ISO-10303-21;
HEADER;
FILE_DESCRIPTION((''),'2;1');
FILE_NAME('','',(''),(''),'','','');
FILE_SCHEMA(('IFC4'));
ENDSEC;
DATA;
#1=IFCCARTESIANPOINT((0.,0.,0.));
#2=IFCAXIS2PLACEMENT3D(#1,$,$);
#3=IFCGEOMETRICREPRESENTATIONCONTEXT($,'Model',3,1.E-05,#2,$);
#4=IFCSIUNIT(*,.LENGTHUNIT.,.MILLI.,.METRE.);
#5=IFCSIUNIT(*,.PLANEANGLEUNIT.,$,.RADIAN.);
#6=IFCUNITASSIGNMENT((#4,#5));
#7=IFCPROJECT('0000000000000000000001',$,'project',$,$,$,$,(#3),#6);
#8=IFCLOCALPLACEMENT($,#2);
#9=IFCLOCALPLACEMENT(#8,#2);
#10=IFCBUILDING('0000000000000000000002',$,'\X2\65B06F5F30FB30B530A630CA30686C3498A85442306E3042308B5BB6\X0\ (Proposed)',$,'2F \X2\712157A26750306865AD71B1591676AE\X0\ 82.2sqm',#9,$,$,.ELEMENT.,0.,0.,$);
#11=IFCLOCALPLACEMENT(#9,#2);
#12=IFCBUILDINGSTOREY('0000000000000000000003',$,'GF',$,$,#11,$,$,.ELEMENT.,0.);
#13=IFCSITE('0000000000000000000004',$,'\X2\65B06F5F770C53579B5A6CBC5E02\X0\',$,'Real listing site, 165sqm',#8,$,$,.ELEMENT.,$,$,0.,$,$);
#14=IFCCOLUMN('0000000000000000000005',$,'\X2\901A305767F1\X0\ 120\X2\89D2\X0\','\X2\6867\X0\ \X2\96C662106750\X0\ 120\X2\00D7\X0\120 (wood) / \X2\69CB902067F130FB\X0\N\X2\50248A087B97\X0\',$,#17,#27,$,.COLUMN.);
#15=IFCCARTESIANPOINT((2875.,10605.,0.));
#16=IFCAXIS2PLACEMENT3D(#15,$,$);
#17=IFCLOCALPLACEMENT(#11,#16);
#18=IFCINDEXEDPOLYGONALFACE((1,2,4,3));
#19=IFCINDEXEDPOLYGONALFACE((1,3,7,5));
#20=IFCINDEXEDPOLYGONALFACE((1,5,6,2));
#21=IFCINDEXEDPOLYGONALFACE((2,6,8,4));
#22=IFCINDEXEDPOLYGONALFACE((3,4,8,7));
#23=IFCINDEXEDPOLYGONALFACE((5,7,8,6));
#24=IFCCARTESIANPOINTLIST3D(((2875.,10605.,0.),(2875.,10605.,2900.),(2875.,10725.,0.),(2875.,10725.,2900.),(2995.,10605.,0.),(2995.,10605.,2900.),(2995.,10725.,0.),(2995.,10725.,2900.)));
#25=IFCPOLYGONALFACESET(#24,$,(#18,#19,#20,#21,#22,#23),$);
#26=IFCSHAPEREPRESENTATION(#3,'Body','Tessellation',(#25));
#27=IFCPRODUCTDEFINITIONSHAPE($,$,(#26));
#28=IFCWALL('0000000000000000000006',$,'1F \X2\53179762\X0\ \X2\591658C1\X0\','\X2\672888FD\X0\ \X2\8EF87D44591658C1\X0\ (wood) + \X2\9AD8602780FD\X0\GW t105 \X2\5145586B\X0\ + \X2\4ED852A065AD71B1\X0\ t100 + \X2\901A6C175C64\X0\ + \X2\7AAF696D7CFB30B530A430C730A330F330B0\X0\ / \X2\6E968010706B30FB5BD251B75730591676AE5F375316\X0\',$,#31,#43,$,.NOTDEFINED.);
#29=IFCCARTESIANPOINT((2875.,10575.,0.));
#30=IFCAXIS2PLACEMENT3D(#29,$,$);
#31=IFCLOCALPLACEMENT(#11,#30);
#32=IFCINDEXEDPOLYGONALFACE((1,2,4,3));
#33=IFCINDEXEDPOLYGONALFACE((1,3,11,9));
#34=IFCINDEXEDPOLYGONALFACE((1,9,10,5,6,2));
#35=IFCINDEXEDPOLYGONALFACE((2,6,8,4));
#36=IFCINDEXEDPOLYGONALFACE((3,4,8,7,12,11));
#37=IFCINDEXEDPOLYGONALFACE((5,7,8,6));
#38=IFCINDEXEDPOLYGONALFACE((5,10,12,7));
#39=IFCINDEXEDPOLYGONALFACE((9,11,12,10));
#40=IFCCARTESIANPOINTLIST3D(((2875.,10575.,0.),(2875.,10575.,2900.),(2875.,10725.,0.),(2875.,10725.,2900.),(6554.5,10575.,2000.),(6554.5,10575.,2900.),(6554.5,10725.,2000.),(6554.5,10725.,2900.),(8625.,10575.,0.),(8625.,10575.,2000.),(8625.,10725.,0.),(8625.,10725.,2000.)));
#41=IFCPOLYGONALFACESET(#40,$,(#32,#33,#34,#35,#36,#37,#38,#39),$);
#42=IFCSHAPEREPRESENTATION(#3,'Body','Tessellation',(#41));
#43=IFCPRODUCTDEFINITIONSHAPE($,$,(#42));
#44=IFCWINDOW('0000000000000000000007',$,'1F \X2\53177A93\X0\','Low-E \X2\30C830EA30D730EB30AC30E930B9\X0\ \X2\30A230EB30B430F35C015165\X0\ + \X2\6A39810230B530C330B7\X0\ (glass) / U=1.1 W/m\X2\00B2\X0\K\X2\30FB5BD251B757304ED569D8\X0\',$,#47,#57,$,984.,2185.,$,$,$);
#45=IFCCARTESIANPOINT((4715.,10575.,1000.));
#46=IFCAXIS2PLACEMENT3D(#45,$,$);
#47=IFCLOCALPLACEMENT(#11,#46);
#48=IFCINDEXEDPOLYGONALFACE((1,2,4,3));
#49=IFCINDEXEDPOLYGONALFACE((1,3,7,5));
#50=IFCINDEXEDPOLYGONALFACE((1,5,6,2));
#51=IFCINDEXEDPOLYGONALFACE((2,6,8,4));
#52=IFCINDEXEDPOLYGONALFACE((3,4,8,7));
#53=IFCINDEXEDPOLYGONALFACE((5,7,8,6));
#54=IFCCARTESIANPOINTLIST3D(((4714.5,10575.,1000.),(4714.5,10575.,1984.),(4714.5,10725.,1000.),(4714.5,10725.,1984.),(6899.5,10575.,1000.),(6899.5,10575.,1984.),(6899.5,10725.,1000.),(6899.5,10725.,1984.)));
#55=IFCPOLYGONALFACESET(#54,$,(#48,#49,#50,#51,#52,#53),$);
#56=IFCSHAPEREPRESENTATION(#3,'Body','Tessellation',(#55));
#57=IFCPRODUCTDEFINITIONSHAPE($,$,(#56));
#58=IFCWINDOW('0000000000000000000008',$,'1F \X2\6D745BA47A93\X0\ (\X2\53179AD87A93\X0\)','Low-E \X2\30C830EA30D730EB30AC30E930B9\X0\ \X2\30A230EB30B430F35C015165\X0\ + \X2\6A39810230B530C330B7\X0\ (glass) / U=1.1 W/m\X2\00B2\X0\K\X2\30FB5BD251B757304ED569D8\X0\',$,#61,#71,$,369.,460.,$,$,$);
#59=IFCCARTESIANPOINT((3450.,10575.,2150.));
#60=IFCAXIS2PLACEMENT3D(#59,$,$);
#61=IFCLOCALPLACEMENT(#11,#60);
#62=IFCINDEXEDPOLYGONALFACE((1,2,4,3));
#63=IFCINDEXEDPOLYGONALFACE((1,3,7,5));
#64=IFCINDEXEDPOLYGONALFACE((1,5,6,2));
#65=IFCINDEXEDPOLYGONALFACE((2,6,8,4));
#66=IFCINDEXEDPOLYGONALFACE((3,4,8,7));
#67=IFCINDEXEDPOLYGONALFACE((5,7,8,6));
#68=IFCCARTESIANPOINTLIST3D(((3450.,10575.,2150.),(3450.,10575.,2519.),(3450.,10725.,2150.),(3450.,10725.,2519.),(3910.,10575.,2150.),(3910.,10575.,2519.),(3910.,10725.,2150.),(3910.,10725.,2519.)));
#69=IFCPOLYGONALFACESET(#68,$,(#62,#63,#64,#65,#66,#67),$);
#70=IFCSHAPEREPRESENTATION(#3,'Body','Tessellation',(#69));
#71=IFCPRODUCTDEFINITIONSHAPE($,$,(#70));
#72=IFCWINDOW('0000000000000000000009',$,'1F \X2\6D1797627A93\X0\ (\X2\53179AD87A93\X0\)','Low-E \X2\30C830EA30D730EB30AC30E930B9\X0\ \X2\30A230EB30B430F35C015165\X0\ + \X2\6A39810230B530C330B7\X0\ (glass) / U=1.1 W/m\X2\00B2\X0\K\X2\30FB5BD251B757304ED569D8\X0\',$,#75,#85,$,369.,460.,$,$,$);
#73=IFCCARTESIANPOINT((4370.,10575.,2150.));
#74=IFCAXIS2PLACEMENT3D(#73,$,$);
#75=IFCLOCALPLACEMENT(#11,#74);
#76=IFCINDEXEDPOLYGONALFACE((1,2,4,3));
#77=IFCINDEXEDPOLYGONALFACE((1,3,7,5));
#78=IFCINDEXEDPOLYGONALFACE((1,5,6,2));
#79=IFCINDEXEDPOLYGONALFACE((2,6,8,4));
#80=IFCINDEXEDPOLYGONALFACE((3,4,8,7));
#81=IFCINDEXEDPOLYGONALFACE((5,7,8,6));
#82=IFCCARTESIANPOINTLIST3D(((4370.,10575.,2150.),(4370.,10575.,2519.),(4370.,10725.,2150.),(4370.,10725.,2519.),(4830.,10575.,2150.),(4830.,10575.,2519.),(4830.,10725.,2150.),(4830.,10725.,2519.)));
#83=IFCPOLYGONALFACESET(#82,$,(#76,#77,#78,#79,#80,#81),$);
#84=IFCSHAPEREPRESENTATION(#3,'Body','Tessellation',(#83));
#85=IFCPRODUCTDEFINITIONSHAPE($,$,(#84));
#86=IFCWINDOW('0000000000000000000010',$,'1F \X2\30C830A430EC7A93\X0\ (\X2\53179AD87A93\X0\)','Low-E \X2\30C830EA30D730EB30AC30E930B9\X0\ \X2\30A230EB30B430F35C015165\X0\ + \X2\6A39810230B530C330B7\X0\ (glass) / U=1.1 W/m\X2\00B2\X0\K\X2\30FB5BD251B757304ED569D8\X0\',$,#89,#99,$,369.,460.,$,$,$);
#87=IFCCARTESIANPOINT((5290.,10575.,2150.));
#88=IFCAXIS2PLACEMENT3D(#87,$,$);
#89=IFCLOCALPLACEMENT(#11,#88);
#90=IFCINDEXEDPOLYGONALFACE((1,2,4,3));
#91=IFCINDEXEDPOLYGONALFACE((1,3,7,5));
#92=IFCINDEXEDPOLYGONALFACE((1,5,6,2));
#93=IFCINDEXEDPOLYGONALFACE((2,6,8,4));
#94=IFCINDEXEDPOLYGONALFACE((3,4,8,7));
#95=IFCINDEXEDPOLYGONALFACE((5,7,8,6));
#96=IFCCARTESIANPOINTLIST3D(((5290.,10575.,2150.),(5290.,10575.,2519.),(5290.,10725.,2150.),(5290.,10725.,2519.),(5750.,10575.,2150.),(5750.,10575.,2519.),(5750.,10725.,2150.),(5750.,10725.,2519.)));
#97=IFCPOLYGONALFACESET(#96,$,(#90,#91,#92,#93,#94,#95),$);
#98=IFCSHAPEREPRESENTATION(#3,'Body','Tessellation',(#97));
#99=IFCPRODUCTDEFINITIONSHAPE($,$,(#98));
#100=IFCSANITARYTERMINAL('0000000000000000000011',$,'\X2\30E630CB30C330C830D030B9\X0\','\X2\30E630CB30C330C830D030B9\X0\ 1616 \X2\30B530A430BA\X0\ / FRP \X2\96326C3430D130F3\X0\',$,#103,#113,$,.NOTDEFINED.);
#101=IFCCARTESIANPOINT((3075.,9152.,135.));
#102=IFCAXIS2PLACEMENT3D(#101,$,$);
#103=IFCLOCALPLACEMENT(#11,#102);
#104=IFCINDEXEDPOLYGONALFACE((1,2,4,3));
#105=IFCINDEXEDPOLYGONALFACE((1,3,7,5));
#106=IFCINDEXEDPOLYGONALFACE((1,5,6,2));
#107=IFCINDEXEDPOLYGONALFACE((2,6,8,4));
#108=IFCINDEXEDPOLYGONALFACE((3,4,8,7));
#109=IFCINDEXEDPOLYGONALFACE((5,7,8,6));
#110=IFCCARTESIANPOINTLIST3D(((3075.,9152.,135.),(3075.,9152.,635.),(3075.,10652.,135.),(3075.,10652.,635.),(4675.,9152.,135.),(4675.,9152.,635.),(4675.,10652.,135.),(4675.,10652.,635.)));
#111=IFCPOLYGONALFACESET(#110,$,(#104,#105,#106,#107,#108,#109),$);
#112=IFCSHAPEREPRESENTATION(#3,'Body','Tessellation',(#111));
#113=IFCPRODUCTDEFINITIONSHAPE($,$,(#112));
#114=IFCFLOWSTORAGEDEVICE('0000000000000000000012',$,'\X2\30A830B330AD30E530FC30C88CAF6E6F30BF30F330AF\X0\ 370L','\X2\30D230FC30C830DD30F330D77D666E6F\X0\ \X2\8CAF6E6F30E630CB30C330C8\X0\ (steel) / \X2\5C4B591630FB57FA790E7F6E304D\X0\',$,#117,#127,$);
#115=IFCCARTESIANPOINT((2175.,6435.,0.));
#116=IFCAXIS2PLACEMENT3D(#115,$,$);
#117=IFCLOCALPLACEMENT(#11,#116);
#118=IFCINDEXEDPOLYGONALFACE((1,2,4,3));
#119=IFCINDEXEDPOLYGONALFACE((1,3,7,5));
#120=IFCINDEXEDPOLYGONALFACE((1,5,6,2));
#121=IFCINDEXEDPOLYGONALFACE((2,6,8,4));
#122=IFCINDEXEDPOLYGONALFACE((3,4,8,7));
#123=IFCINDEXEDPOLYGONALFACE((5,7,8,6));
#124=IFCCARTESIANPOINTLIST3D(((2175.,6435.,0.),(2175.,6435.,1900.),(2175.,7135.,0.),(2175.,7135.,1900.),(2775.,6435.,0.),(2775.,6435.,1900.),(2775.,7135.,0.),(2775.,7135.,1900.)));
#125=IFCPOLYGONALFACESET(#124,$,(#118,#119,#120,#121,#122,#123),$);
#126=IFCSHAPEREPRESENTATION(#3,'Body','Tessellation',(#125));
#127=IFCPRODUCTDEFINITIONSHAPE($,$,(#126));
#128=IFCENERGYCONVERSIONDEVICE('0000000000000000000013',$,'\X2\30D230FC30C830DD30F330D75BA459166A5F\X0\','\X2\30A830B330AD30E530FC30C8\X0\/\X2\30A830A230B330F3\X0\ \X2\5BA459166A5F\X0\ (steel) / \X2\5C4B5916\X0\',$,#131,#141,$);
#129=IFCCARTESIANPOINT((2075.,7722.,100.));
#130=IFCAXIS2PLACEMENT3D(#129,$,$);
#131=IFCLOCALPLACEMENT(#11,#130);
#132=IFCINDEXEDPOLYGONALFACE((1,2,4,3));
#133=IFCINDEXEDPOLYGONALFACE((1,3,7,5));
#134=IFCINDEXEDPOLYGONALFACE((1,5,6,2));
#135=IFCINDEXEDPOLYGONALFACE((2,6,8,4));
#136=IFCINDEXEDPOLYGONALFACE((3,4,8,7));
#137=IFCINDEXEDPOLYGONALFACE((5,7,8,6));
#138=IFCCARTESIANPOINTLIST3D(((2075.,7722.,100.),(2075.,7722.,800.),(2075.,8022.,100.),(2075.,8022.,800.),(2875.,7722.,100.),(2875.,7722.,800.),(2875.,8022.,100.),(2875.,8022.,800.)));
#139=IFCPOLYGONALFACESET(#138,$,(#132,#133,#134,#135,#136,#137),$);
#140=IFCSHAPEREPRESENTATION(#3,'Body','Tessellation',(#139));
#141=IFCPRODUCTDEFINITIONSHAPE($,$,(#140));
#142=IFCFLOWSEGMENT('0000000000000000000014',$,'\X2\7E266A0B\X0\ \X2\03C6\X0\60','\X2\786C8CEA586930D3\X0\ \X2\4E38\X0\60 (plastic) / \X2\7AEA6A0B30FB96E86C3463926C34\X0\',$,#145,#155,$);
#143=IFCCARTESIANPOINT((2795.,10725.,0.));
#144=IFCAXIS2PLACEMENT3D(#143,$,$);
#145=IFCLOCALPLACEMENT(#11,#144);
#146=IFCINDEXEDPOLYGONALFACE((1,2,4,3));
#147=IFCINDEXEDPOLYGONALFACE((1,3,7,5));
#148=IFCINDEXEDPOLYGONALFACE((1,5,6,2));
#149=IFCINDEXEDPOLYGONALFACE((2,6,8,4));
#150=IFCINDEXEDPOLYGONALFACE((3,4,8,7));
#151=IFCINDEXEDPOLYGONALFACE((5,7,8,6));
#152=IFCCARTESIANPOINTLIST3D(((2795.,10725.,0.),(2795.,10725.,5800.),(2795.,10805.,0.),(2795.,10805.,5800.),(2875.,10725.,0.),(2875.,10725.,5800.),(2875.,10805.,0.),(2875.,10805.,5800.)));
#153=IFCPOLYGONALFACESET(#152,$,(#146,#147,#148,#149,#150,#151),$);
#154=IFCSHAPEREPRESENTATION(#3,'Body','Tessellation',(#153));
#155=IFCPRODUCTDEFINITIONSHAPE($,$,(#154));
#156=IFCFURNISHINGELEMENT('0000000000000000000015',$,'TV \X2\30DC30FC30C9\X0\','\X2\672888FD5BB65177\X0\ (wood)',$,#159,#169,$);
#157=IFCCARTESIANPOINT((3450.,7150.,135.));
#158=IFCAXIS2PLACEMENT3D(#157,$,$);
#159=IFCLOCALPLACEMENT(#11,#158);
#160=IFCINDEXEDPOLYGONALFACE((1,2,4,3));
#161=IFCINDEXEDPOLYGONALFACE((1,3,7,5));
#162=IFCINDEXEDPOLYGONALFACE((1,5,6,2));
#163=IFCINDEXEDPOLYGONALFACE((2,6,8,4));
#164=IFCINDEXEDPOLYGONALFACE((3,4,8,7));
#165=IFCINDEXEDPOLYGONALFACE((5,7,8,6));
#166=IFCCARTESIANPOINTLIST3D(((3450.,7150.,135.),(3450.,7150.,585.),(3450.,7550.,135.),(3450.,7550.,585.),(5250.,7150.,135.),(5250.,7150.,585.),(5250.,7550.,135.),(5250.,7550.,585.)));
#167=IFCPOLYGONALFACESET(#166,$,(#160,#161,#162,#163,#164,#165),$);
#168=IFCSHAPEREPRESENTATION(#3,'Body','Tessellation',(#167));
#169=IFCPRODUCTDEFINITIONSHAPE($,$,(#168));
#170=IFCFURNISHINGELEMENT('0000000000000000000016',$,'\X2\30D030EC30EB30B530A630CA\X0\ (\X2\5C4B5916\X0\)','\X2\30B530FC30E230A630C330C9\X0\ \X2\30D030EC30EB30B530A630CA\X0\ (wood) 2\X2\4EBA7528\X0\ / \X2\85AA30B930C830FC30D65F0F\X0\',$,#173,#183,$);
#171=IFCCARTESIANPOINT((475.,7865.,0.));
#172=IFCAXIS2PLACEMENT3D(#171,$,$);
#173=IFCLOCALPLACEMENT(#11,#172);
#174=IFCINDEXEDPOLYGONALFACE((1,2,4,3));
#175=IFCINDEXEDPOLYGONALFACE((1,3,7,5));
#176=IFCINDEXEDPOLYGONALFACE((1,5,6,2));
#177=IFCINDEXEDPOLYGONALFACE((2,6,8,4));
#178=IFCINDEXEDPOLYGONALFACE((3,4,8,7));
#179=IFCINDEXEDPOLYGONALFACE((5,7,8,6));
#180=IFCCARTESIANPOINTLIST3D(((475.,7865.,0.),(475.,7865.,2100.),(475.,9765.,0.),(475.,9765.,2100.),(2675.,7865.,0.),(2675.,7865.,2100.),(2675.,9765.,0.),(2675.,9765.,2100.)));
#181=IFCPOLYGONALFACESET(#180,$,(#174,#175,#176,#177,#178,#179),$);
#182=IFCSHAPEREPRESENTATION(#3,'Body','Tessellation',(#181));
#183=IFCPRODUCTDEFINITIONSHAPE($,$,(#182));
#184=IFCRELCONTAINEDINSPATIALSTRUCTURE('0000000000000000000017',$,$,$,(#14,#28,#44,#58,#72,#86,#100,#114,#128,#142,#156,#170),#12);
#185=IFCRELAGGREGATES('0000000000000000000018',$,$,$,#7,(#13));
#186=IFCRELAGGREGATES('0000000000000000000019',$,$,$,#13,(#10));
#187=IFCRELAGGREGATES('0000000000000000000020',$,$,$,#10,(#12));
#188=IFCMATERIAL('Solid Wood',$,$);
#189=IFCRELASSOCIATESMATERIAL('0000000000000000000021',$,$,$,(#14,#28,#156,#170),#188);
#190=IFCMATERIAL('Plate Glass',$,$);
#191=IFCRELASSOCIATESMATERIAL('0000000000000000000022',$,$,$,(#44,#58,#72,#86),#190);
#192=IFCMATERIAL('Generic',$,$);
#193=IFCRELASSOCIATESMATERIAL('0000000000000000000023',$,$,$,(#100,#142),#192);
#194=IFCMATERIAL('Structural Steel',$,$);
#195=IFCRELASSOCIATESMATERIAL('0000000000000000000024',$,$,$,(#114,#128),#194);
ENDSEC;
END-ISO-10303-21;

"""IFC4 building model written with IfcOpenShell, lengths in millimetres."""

from ifc_helpers import new_model, si_unit, frame, frame_2d, origin, place, context, project, spatial, rectangle, extrude, material, element, fill, save


model = new_model("IFC4")

# Units and contexts
model_context = context("Model", 3, precision=1e-05, world=origin())
ifc_project = project(units=[si_unit("LENGTHUNIT", "METRE", prefix="MILLI"), si_unit("PLANEANGLEUNIT", "RADIAN")], contexts=[model_context])

# Site, building, storey
site_placement = place(None, origin())
site = spatial("IfcSite", under=ifc_project, at=site_placement, Name="新潟県南魚沼市", ObjectType="Real listing site, 165sqm", CompositionType="ELEMENT", RefElevation=0.0)
building_placement = place(site_placement, origin())
building = spatial("IfcBuilding", under=site, at=building_placement, Name="新潟・サウナと水風呂のある家 (Proposed)", ObjectType="2F 無垢材と断熱外皮 82.2sqm", CompositionType="ELEMENT", ElevationOfRefHeight=0.0, ElevationOfTerrain=0.0)
storey_placement = place(building_placement, origin())
storey = spatial("IfcBuildingStorey", under=building, at=storey_placement, Name="GF", CompositionType="ELEMENT", Elevation=0.0)

# Column
ifc_material_1 = material(Name="Solid Wood")
column_1_placement = place(storey_placement, frame((2875.0, 10605.0, 0.0)))
element("IfcColumn", 1, at=column_1_placement, inside=storey, material=ifc_material_1, Name="通し柱 120角", Description="桧 集成材 120×120 (wood) / 構造柱・N値計算", PredefinedType="COLUMN", context=model_context, shape_type="SweptSolid", body=[
    extrude(rectangle(XDim=120.0, YDim=120.0, at=frame_2d((60.0, 60.0))), frame((2875.0, 10605.0, 0.0)), (0.0, 0.0, 1.0), 2900.0),
])

# Wall, openings, windows
wall_1_placement = place(storey_placement, frame((2875.0, 10575.0, 0.0)))
wall_1 = element("IfcWall", 2, at=wall_1_placement, inside=storey, material=ifc_material_1, Name="1F 北面 外壁", Description="木製 軸組外壁 (wood) + 高性能GW t105 充填 + 付加断熱 t100 + 通気層 + 窯業系サイディング / 準耐火・寒冷地外皮強化", PredefinedType="NOTDEFINED", context=model_context, shape_type="SweptSolid", body=[
    extrude(rectangle(XDim=5750.0, YDim=150.0, at=frame_2d((2875.0, 75.0))), frame((2875.0, 10575.0, 0.0)), (0.0, 0.0, 1.0), 2900.0),
])
opening_1_placement = place(storey_placement, frame((4715.0, 10575.0, 1000.0)))
opening_1 = element("IfcOpeningElement", 3, at=opening_1_placement, cuts=wall_1, PredefinedType="NOTDEFINED", context=model_context, shape_type="SweptSolid", body=[
    extrude(rectangle(XDim=2185.0, YDim=150.0, at=frame_2d((1092.0, 75.0))), frame((4715.0, 10575.0, 1000.0)), (0.0, 0.0, 1.0), 984.0),
])
opening_2_placement = place(storey_placement, frame((3450.0, 10575.0, 2150.0)))
opening_2 = element("IfcOpeningElement", 4, at=opening_2_placement, cuts=wall_1, PredefinedType="NOTDEFINED", context=model_context, shape_type="SweptSolid", body=[
    extrude(rectangle(XDim=460.0, YDim=150.0, at=frame_2d((230.0, 75.0))), frame((3450.0, 10575.0, 2150.0)), (0.0, 0.0, 1.0), 369.0),
])
opening_3_placement = place(storey_placement, frame((4370.0, 10575.0, 2150.0)))
opening_3 = element("IfcOpeningElement", 5, at=opening_3_placement, cuts=wall_1, PredefinedType="NOTDEFINED", context=model_context, shape_type="SweptSolid", body=[
    extrude(rectangle(XDim=460.0, YDim=150.0, at=frame_2d((230.0, 75.0))), frame((4370.0, 10575.0, 2150.0)), (0.0, 0.0, 1.0), 369.0),
])
opening_4_placement = place(storey_placement, frame((5290.0, 10575.0, 2150.0)))
opening_4 = element("IfcOpeningElement", 6, at=opening_4_placement, cuts=wall_1, PredefinedType="NOTDEFINED", context=model_context, shape_type="SweptSolid", body=[
    extrude(rectangle(XDim=460.0, YDim=150.0, at=frame_2d((230.0, 75.0))), frame((5290.0, 10575.0, 2150.0)), (0.0, 0.0, 1.0), 369.0),
])
ifc_material_2 = material(Name="Plate Glass")
window_1_placement = place(storey_placement, frame((4715.0, 10575.0, 1000.0)))
window_1 = element("IfcWindow", 7, at=window_1_placement, inside=storey, material=ifc_material_2, Name="1F 北窓", Description="Low-E トリプルガラス アルゴン封入 + 樹脂サッシ (glass) / U=1.1 W/m²K・寒冷地仕様", OverallHeight=984.0, OverallWidth=2185.0, context=model_context, shape_type="SweptSolid", body=[
    extrude(rectangle(XDim=2185.0, YDim=150.0, at=frame_2d((1092.0, 75.0))), frame((4715.0, 10575.0, 1000.0)), (0.0, 0.0, 1.0), 984.0),
])
fill(opening_1, window_1)
window_2_placement = place(storey_placement, frame((3450.0, 10575.0, 2150.0)))
window_2 = element("IfcWindow", 8, at=window_2_placement, inside=storey, material=ifc_material_2, Name="1F 浴室窓 (北高窓)", Description="Low-E トリプルガラス アルゴン封入 + 樹脂サッシ (glass) / U=1.1 W/m²K・寒冷地仕様", OverallHeight=369.0, OverallWidth=460.0, context=model_context, shape_type="SweptSolid", body=[
    extrude(rectangle(XDim=460.0, YDim=150.0, at=frame_2d((230.0, 75.0))), frame((3450.0, 10575.0, 2150.0)), (0.0, 0.0, 1.0), 369.0),
])
fill(opening_2, window_2)
window_3_placement = place(storey_placement, frame((4370.0, 10575.0, 2150.0)))
window_3 = element("IfcWindow", 9, at=window_3_placement, inside=storey, material=ifc_material_2, Name="1F 洗面窓 (北高窓)", Description="Low-E トリプルガラス アルゴン封入 + 樹脂サッシ (glass) / U=1.1 W/m²K・寒冷地仕様", OverallHeight=369.0, OverallWidth=460.0, context=model_context, shape_type="SweptSolid", body=[
    extrude(rectangle(XDim=460.0, YDim=150.0, at=frame_2d((230.0, 75.0))), frame((4370.0, 10575.0, 2150.0)), (0.0, 0.0, 1.0), 369.0),
])
fill(opening_3, window_3)
window_4_placement = place(storey_placement, frame((5290.0, 10575.0, 2150.0)))
window_4 = element("IfcWindow", 10, at=window_4_placement, inside=storey, material=ifc_material_2, Name="1F トイレ窓 (北高窓)", Description="Low-E トリプルガラス アルゴン封入 + 樹脂サッシ (glass) / U=1.1 W/m²K・寒冷地仕様", OverallHeight=369.0, OverallWidth=460.0, context=model_context, shape_type="SweptSolid", body=[
    extrude(rectangle(XDim=460.0, YDim=150.0, at=frame_2d((230.0, 75.0))), frame((5290.0, 10575.0, 2150.0)), (0.0, 0.0, 1.0), 369.0),
])
fill(opening_4, window_4)

# Sanitary terminal
ifc_material_3 = material(Name="Generic")
sanitary_terminal_placement = place(storey_placement, frame((3075.0, 9152.0, 135.0)))
element("IfcSanitaryTerminal", 11, at=sanitary_terminal_placement, inside=storey, material=ifc_material_3, Name="ユニットバス", Description="ユニットバス 1616 サイズ / FRP 防水パン", PredefinedType="NOTDEFINED", context=model_context, shape_type="SweptSolid", body=[
    extrude(rectangle(XDim=1600.0, YDim=1500.0, at=frame_2d((800.0, 750.0))), frame((3075.0, 9152.0, 135.0)), (0.0, 0.0, 1.0), 500.0),
])

# Flow storage device
ifc_material_4 = material(Name="Structural Steel")
flow_storage_device_placement = place(storey_placement, frame((2175.0, 6435.0, 0.0)))
element("IfcFlowStorageDevice", 12, at=flow_storage_device_placement, inside=storey, material=ifc_material_4, Name="エコキュート貯湯タンク 370L", Description="ヒートポンプ給湯 貯湯ユニット (steel) / 屋外・基礎置き", context=model_context, shape_type="SweptSolid", body=[
    extrude(rectangle(XDim=600.0, YDim=700.0, at=frame_2d((300.0, 350.0))), frame((2175.0, 6435.0, 0.0)), (0.0, 0.0, 1.0), 1900.0),
])

# Energy conversion device
energy_conversion_device_placement = place(storey_placement, frame((2075.0, 7722.0, 100.0)))
element("IfcEnergyConversionDevice", 13, at=energy_conversion_device_placement, inside=storey, material=ifc_material_4, Name="ヒートポンプ室外機", Description="エコキュート/エアコン 室外機 (steel) / 屋外", context=model_context, shape_type="SweptSolid", body=[
    extrude(rectangle(XDim=800.0, YDim=300.0, at=frame_2d((400.0, 150.0))), frame((2075.0, 7722.0, 100.0)), (0.0, 0.0, 1.0), 700.0),
])

# Flow segment
flow_segment_placement = place(storey_placement, frame((2795.0, 10725.0, 0.0)))
element("IfcFlowSegment", 14, at=flow_segment_placement, inside=storey, material=ifc_material_3, Name="縦樋 φ60", Description="硬質塩ビ 丸60 (plastic) / 竪樋・雨水排水", context=model_context, shape_type="SweptSolid", body=[
    extrude(rectangle(XDim=80.0, YDim=80.0, at=frame_2d((40.0, 40.0))), frame((2795.0, 10725.0, 0.0)), (0.0, 0.0, 1.0), 5800.0),
])

# Furnishing elements
furnishing_1_placement = place(storey_placement, frame((3450.0, 7150.0, 135.0)))
element("IfcFurnishingElement", 15, at=furnishing_1_placement, inside=storey, material=ifc_material_1, Name="TV ボード", Description="木製家具 (wood)", context=model_context, shape_type="SweptSolid", body=[
    extrude(rectangle(XDim=1800.0, YDim=400.0, at=frame_2d((900.0, 200.0))), frame((3450.0, 7150.0, 135.0)), (0.0, 0.0, 1.0), 450.0),
])
furnishing_2_placement = place(storey_placement, frame((475.0, 7865.0, 0.0)))
element("IfcFurnishingElement", 16, at=furnishing_2_placement, inside=storey, material=ifc_material_1, Name="バレルサウナ (屋外)", Description="サーモウッド バレルサウナ (wood) 2人用 / 薪ストーブ式", context=model_context, shape_type="SweptSolid", body=[
    extrude(rectangle(XDim=2200.0, YDim=1900.0, at=frame_2d((1100.0, 950.0))), frame((475.0, 7865.0, 0.0)), (0.0, 0.0, 1.0), 2100.0),
])

save(model, "model.ifc")
